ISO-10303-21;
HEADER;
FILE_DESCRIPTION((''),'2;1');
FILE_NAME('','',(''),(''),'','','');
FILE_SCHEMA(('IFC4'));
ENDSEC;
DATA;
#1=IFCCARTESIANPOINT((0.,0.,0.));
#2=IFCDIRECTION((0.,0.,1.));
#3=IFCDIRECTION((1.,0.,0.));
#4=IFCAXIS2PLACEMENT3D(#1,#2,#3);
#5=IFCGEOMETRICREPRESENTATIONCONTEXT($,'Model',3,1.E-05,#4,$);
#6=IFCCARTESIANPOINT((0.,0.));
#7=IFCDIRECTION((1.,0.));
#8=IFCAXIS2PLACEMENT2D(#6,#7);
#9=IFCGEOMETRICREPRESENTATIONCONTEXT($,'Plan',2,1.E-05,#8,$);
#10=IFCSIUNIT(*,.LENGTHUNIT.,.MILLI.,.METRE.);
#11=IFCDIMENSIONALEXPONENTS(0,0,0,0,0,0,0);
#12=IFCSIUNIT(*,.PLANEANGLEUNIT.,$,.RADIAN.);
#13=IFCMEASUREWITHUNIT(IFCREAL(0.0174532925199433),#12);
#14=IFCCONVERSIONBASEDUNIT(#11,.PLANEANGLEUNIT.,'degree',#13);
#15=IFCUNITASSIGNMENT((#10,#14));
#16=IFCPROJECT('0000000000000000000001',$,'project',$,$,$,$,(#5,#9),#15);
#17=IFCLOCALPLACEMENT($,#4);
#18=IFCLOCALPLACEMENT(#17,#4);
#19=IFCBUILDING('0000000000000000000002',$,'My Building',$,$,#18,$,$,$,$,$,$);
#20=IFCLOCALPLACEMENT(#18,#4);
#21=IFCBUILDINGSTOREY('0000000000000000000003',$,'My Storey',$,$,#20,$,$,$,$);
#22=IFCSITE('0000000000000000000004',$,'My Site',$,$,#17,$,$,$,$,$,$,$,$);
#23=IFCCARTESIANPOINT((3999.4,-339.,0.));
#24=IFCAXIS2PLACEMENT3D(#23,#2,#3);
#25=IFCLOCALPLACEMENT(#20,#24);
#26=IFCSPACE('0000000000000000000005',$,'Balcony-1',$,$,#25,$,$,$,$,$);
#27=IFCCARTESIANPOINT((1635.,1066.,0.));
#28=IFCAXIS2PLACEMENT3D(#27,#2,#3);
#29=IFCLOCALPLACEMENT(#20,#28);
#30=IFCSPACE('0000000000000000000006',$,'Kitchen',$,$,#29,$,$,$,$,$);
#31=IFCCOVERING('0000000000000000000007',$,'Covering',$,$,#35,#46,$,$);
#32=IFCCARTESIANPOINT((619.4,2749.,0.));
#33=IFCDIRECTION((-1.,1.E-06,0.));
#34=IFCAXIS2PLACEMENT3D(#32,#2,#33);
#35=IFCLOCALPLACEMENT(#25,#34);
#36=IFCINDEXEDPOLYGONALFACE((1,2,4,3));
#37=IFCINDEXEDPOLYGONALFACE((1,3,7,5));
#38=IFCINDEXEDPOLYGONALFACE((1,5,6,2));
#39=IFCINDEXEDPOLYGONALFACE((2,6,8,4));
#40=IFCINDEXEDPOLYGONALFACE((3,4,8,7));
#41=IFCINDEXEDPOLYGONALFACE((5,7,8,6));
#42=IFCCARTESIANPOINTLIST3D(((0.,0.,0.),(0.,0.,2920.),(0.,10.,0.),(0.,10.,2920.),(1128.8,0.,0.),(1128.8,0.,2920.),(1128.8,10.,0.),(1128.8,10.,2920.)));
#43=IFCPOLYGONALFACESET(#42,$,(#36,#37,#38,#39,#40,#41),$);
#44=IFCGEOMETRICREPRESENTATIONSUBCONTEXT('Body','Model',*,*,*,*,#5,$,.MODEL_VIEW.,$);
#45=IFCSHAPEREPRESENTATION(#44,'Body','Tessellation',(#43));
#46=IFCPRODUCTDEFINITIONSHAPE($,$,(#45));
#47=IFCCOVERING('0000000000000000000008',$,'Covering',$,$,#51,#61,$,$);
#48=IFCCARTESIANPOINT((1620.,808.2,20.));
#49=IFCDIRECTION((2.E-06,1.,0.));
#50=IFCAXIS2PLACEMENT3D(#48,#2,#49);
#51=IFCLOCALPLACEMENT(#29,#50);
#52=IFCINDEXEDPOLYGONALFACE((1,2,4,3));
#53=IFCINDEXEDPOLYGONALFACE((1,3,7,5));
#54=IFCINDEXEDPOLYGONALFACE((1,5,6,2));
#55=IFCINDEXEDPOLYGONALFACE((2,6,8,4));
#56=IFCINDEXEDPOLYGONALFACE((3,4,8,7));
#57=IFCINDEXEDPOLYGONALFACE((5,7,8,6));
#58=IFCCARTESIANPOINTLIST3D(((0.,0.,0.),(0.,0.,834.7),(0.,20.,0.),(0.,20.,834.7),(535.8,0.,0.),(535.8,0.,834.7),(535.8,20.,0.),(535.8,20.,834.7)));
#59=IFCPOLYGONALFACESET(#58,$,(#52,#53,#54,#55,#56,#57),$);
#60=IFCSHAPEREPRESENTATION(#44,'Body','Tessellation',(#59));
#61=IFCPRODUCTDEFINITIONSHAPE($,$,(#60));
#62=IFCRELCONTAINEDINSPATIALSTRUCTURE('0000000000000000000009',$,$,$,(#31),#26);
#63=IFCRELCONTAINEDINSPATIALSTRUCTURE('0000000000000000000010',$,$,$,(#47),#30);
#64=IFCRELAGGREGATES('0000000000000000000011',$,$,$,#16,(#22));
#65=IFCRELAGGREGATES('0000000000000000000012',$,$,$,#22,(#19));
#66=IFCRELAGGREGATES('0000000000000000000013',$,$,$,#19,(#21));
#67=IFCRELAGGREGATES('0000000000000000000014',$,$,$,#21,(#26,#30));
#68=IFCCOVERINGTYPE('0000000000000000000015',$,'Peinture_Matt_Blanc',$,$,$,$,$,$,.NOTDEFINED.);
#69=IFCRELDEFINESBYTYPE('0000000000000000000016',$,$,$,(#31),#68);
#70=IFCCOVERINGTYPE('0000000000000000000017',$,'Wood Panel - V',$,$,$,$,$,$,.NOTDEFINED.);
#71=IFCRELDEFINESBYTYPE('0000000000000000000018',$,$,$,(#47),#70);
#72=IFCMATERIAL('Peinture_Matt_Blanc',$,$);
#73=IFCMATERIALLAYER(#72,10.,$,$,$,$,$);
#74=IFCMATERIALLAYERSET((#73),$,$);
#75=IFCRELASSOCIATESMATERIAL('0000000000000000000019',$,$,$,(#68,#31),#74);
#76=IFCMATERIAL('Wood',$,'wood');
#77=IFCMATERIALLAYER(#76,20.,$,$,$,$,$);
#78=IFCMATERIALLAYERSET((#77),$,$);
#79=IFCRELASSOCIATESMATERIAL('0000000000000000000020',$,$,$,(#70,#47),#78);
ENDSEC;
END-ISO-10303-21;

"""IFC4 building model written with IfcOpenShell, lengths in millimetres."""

from ifc_helpers import new_model, entity, si_unit, converted_unit, frame, origin_with_axes, origin_2d_with_axis, place, context, subcontext, project, spatial, indexed_curve, outline, extrude, clip, halfspace, material, layer, layer_set, layer_usage, type_object, element, save


model = new_model("IFC4")

# Units and contexts
model_context = context("Model", 3, precision=1e-05, world=origin_with_axes())
plan_context = context("Plan", 2, precision=1e-05, world=origin_2d_with_axis())
body_context = subcontext(model_context, "Body", "Model", "MODEL_VIEW")
ifc_project = project(units=[si_unit("LENGTHUNIT", "METRE", prefix="MILLI"), converted_unit("PLANEANGLEUNIT", "degree", entity("IfcReal", 0.0174532925199433), si_unit("PLANEANGLEUNIT", "RADIAN"), dimensions=[0, 0, 0, 0, 0, 0, 0])], contexts=[model_context, plan_context])

# Site, building, storey, space
site_placement = place(None, origin_with_axes())
site = spatial("IfcSite", under=ifc_project, at=site_placement, Name="My Site")
building_placement = place(site_placement, origin_with_axes())
building = spatial("IfcBuilding", under=site, at=building_placement, Name="My Building")
storey_placement = place(building_placement, origin_with_axes())
storey = spatial("IfcBuildingStorey", under=building, at=storey_placement, Name="My Storey")
space_1_placement = place(storey_placement, frame((3999.4, -339.0, 0.0), z_axis=(0.0, 0.0, 1.0), x_axis=(1.0, 0.0, 0.0)))
space_1 = spatial("IfcSpace", under=storey, at=space_1_placement, Name="Balcony-1")

# Shared definitions
ifc_material_1 = material(Name="Peinture_Matt_Blanc")
ifc_layer_1 = layer(ifc_material_1, 10.0)
ifc_layer_set_1 = layer_set([ifc_layer_1])
covering_type_1 = type_object("IfcCoveringType", Name="Peinture_Matt_Blanc", PredefinedType="NOTDEFINED", material=ifc_layer_set_1)

# Covering
ifc_layer_usage_1 = layer_usage(ifc_layer_set_1, "AXIS2", "POSITIVE", 0.0)
covering_1_placement = place(space_1_placement, frame((619.4, 2749.0, 0.0), z_axis=(0.0, 0.0, 1.0), x_axis=(-1.0, 0.000001, 0.0)))
element("IfcCovering", 1, at=covering_1_placement, inside=space_1, type_object=covering_type_1, material=ifc_layer_usage_1, Name="Covering", context=body_context, shape_type="Clipping", body=[
    clip(clip(extrude(outline(indexed_curve([(0.0, 0.0), (0.0, 10.0), (1128.8, 10.0), (1128.8, 0.0), (0.0, 0.0)], self_intersect=False)), origin_with_axes(), (0.0, 0.0, 1.0), 2920.0), halfspace(frame((0.0, 0.0, 2920.0), z_axis=(0.0, 0.0, 1.0), x_axis=(-1.0, 0.0, 0.0)), False)), halfspace(frame((0.0, 0.0, 2920.0), z_axis=(0.0, 0.0, 1.0), x_axis=(-1.0, 0.0, 0.0)), False)),
])

# Shared definitions
space_2_placement = place(storey_placement, frame((1635.0, 1066.0, 0.0), z_axis=(0.0, 0.0, 1.0), x_axis=(1.0, 0.0, 0.0)))
space_2 = spatial("IfcSpace", under=storey, at=space_2_placement, Name="Kitchen")

# Covering
ifc_material_2 = material(Name="Wood", Category="wood")
ifc_layer_2 = layer(ifc_material_2, 20.0)
ifc_layer_set_2 = layer_set([ifc_layer_2])
ifc_layer_usage_2 = layer_usage(ifc_layer_set_2, "AXIS2", "POSITIVE", 0.0)
covering_type_2 = type_object("IfcCoveringType", Name="Wood Panel - V", PredefinedType="NOTDEFINED", material=ifc_layer_set_2)
covering_2_placement = place(space_2_placement, frame((1620.0, 808.2, 20.0), z_axis=(0.0, 0.0, 1.0), x_axis=(0.000002, 1.0, 0.0)))
element("IfcCovering", 2, at=covering_2_placement, inside=space_2, type_object=covering_type_2, material=ifc_layer_usage_2, Name="Covering", context=body_context, shape_type="Clipping", body=[
    clip(extrude(outline(indexed_curve([(0.0, 0.0), (0.0, 20.0), (535.8, 20.0), (535.8, 0.0), (0.0, 0.0)], self_intersect=False)), origin_with_axes(), (0.0, 0.0, 1.0), 834.7), halfspace(frame((0.0, 0.0, 834.7), z_axis=(0.0, 0.0, 1.0), x_axis=(-1.0, 0.0, 0.0)), False)),
])

save(model, "model.ifc")
